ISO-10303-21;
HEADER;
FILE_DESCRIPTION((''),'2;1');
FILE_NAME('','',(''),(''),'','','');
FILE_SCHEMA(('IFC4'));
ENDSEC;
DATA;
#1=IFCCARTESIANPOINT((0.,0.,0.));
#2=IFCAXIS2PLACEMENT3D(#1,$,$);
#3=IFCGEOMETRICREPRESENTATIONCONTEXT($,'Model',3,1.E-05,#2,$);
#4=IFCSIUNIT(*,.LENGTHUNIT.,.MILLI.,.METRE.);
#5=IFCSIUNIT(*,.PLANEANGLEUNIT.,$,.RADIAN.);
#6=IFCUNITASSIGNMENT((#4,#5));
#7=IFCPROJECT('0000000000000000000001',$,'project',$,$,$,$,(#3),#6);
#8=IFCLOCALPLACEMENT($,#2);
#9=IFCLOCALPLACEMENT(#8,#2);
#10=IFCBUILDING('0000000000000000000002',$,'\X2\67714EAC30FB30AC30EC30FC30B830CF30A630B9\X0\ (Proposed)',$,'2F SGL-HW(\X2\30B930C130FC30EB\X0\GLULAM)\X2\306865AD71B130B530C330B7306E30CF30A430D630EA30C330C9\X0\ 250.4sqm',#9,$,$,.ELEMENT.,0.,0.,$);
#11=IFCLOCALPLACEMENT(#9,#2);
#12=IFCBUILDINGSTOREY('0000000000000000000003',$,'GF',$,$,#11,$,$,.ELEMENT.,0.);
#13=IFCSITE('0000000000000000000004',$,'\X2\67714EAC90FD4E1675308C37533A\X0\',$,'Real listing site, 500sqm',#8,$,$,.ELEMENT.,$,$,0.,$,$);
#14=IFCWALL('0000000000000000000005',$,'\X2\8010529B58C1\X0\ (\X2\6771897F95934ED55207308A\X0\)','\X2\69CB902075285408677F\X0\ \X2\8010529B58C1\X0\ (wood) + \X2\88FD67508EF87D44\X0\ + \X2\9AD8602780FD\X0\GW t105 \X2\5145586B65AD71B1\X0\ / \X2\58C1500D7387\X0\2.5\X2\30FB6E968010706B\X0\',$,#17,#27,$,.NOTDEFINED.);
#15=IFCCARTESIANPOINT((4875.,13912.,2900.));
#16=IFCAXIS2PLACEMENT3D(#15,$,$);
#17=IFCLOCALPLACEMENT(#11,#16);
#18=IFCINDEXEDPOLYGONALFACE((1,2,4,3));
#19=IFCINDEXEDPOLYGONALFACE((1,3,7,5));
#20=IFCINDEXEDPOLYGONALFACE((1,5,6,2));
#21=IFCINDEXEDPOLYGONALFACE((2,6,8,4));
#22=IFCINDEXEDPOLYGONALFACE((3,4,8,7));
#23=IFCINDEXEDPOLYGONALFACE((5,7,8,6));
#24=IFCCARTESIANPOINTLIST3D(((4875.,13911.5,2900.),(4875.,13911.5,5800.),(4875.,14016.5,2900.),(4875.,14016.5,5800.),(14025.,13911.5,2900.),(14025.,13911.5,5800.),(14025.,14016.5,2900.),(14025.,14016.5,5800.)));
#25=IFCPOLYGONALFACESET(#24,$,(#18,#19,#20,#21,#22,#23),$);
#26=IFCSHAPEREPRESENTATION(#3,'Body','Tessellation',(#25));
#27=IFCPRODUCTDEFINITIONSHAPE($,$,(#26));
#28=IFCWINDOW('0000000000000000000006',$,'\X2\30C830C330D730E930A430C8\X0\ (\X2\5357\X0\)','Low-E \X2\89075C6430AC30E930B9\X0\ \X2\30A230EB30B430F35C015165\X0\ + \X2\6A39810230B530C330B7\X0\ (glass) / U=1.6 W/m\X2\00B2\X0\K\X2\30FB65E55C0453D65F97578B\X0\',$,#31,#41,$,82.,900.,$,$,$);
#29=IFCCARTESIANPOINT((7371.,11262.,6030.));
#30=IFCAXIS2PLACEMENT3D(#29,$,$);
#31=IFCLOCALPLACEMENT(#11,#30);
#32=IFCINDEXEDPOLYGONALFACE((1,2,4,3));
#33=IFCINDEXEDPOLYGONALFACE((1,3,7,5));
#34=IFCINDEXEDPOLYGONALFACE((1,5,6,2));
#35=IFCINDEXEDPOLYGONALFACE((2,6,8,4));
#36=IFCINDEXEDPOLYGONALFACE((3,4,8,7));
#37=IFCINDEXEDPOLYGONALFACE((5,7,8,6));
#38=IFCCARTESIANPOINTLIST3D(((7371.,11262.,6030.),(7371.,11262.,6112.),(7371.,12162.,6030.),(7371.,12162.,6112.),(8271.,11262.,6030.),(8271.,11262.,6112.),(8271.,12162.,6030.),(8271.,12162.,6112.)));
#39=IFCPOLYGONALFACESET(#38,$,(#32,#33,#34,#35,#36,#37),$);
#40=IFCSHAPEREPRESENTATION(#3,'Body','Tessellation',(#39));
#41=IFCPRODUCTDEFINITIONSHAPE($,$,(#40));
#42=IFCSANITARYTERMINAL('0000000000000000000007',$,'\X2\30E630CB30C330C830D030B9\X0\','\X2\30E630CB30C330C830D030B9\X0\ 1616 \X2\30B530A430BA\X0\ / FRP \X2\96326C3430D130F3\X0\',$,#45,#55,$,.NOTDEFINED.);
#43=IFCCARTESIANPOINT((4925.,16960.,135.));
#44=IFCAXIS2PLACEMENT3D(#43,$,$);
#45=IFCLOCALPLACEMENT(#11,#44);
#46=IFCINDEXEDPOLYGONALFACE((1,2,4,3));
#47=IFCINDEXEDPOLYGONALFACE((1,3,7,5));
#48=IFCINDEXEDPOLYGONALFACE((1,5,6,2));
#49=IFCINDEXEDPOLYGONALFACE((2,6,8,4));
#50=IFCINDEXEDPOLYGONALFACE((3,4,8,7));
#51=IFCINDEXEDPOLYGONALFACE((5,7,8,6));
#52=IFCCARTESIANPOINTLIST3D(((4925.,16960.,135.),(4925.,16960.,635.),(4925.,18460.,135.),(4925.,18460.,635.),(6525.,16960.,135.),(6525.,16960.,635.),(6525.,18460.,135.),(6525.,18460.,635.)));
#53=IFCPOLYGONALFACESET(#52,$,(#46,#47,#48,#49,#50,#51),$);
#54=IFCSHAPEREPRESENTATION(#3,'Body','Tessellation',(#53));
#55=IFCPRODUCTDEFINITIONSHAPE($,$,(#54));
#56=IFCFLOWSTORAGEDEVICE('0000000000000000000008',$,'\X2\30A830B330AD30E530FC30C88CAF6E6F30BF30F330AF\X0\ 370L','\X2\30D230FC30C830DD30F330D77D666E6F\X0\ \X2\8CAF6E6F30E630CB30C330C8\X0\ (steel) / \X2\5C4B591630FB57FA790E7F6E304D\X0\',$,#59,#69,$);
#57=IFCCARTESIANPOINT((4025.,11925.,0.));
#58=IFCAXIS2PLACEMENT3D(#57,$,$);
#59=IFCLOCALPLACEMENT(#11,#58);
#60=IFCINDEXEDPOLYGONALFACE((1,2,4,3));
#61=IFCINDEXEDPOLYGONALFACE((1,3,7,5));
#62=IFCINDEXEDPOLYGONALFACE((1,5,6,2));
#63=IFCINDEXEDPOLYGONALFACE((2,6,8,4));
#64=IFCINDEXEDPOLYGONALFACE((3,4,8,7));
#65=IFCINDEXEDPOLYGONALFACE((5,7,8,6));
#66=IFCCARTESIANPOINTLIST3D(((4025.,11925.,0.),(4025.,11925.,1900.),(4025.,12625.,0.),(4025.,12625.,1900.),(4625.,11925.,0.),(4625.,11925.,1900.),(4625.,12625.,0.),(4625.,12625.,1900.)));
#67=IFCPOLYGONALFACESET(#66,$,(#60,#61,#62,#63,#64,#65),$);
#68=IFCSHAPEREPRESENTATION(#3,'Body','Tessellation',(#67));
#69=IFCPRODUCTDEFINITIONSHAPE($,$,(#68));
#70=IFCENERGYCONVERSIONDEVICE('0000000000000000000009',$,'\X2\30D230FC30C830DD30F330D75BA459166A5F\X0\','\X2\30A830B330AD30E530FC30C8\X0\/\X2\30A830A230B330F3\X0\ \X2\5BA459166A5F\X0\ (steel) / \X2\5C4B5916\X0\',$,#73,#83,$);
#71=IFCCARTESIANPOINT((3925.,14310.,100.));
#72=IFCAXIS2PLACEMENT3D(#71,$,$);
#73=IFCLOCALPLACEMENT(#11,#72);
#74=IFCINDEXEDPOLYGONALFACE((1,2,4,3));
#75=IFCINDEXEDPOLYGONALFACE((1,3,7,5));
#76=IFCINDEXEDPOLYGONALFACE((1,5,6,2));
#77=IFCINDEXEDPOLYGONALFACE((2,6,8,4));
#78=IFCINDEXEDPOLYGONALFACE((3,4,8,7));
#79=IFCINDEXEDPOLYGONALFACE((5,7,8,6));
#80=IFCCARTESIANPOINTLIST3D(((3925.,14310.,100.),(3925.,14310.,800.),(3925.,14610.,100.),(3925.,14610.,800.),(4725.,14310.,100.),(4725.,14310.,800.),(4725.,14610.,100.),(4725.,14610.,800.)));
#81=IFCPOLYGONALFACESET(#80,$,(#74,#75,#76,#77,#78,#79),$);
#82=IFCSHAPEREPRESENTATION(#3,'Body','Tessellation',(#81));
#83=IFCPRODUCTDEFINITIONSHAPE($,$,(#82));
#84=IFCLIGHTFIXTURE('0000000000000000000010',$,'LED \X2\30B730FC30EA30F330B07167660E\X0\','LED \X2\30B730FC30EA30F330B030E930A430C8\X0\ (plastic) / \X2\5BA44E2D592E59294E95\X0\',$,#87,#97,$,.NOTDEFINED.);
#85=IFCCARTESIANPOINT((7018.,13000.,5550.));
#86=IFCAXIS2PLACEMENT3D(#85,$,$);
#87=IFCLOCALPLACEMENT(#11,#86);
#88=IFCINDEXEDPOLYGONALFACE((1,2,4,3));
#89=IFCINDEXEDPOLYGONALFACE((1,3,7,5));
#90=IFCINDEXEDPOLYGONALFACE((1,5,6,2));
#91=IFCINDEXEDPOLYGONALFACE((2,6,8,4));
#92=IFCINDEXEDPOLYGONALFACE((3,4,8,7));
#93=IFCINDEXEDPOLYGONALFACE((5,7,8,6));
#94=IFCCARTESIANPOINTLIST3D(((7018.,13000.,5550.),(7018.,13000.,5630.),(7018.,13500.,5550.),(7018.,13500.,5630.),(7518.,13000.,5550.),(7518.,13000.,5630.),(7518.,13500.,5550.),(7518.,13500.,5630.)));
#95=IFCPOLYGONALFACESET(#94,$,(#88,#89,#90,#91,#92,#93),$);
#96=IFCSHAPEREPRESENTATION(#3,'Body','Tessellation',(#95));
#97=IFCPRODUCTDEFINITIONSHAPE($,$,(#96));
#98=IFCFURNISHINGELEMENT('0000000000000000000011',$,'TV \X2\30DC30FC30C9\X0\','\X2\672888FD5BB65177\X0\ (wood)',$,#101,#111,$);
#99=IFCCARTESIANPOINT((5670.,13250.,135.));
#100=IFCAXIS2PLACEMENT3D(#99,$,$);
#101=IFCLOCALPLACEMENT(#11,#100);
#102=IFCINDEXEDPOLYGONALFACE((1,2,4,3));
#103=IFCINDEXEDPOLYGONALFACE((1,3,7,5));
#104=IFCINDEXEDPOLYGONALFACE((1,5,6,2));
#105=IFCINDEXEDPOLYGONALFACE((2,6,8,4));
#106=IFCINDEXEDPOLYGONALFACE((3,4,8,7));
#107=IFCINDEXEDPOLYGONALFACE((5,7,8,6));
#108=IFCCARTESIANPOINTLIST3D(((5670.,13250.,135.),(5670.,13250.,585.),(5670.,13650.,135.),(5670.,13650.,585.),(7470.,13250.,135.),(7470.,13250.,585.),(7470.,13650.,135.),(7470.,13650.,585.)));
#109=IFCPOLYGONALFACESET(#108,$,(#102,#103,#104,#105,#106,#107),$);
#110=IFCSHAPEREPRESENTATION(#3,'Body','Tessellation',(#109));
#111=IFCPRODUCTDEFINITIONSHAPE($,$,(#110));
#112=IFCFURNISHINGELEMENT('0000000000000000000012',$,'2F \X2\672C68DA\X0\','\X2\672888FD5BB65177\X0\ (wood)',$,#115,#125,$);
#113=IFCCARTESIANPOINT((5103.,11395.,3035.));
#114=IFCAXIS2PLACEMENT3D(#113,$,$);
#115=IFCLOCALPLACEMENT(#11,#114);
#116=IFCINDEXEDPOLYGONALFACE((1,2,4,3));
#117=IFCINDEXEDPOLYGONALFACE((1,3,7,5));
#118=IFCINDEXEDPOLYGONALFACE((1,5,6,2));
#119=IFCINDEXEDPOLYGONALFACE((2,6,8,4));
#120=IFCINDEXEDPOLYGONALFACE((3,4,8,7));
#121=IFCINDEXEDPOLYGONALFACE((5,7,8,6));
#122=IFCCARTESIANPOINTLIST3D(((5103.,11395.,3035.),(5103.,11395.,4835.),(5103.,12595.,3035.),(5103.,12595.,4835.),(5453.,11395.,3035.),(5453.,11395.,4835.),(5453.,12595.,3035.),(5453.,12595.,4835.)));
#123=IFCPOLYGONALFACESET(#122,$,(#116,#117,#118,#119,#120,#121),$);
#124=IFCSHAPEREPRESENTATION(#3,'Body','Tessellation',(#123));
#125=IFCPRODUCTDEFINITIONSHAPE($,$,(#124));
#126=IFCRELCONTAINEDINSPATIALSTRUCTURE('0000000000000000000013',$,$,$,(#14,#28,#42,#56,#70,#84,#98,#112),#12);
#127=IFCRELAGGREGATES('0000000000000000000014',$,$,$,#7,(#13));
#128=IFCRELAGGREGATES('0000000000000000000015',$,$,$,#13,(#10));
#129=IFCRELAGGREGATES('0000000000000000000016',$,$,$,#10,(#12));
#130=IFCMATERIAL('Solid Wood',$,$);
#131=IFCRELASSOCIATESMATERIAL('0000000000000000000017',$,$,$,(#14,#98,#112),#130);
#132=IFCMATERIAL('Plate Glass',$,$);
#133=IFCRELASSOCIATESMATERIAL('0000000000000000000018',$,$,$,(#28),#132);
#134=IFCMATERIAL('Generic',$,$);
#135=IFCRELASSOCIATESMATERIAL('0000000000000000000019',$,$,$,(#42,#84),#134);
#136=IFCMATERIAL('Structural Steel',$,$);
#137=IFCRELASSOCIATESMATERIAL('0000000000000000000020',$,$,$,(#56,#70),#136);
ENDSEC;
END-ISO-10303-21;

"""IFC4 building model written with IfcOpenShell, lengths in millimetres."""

from ifc_helpers import new_model, si_unit, frame, frame_2d, origin, place, context, project, spatial, rectangle, extrude, material, element, save


model = new_model("IFC4")

# Units and contexts
model_context = context("Model", 3, precision=1e-05, world=origin())
ifc_project = project(units=[si_unit("LENGTHUNIT", "METRE", prefix="MILLI"), si_unit("PLANEANGLEUNIT", "RADIAN")], contexts=[model_context])

# Site, building, storey
site_placement = place(None, origin())
site = spatial("IfcSite", under=ifc_project, at=site_placement, Name="東京都世田谷区", ObjectType="Real listing site, 500sqm", CompositionType="ELEMENT", RefElevation=0.0)
building_placement = place(site_placement, origin())
building = spatial("IfcBuilding", under=site, at=building_placement, Name="東京・ガレージハウス (Proposed)", ObjectType="2F SGL-HW(スチールGLULAM)と断熱サッシのハイブリッド 250.4sqm", CompositionType="ELEMENT", ElevationOfRefHeight=0.0, ElevationOfTerrain=0.0)
storey_placement = place(building_placement, origin())
storey = spatial("IfcBuildingStorey", under=building, at=storey_placement, Name="GF", CompositionType="ELEMENT", Elevation=0.0)

# Shared definitions
ifc_material_1 = material(Name="Solid Wood")

# Wall
wall_1_placement = place(storey_placement, frame((4875.0, 13912.0, 2900.0)))
element("IfcWall", 1, at=wall_1_placement, inside=storey, material=ifc_material_1, Name="耐力壁 (東西間仕切り)", Description="構造用合板 耐力壁 (wood) + 製材軸組 + 高性能GW t105 充填断熱 / 壁倍率2.5・準耐火", PredefinedType="NOTDEFINED", context=model_context, shape_type="SweptSolid", body=[
    extrude(rectangle(XDim=9150.0, YDim=105.0, at=frame_2d((4575.0, 52.0))), frame((4875.0, 13912.0, 2900.0)), (0.0, 0.0, 1.0), 2900.0),
])

# Window
ifc_material_2 = material(Name="Plate Glass")
window_placement = place(storey_placement, frame((7371.0, 11262.0, 6030.0)))
element("IfcWindow", 2, at=window_placement, inside=storey, material=ifc_material_2, Name="トップライト (南)", Description="Low-E 複層ガラス アルゴン封入 + 樹脂サッシ (glass) / U=1.6 W/m²K・日射取得型", OverallHeight=82.0, OverallWidth=900.0, context=model_context, shape_type="SweptSolid", body=[
    extrude(rectangle(XDim=900.0, YDim=900.0, at=frame_2d((450.0, 450.0))), frame((7371.0, 11262.0, 6030.0)), (0.0, 0.0, 1.0), 82.0),
])

# Sanitary terminal
ifc_material_3 = material(Name="Generic")
sanitary_terminal_placement = place(storey_placement, frame((4925.0, 16960.0, 135.0)))
element("IfcSanitaryTerminal", 3, at=sanitary_terminal_placement, inside=storey, material=ifc_material_3, Name="ユニットバス", Description="ユニットバス 1616 サイズ / FRP 防水パン", PredefinedType="NOTDEFINED", context=model_context, shape_type="SweptSolid", body=[
    extrude(rectangle(XDim=1600.0, YDim=1500.0, at=frame_2d((800.0, 750.0))), frame((4925.0, 16960.0, 135.0)), (0.0, 0.0, 1.0), 500.0),
])

# Flow storage device
ifc_material_4 = material(Name="Structural Steel")
flow_storage_device_placement = place(storey_placement, frame((4025.0, 11925.0, 0.0)))
element("IfcFlowStorageDevice", 4, at=flow_storage_device_placement, inside=storey, material=ifc_material_4, Name="エコキュート貯湯タンク 370L", Description="ヒートポンプ給湯 貯湯ユニット (steel) / 屋外・基礎置き", context=model_context, shape_type="SweptSolid", body=[
    extrude(rectangle(XDim=600.0, YDim=700.0, at=frame_2d((300.0, 350.0))), frame((4025.0, 11925.0, 0.0)), (0.0, 0.0, 1.0), 1900.0),
])

# Energy conversion device
energy_conversion_device_placement = place(storey_placement, frame((3925.0, 14310.0, 100.0)))
element("IfcEnergyConversionDevice", 5, at=energy_conversion_device_placement, inside=storey, material=ifc_material_4, Name="ヒートポンプ室外機", Description="エコキュート/エアコン 室外機 (steel) / 屋外", context=model_context, shape_type="SweptSolid", body=[
    extrude(rectangle(XDim=800.0, YDim=300.0, at=frame_2d((400.0, 150.0))), frame((3925.0, 14310.0, 100.0)), (0.0, 0.0, 1.0), 700.0),
])

# Light fixture
light_fixture_placement = place(storey_placement, frame((7018.0, 13000.0, 5550.0)))
element("IfcLightFixture", 6, at=light_fixture_placement, inside=storey, material=ifc_material_3, Name="LED シーリング照明", Description="LED シーリングライト (plastic) / 室中央天井", PredefinedType="NOTDEFINED", context=model_context, shape_type="SweptSolid", body=[
    extrude(rectangle(XDim=500.0, YDim=500.0, at=frame_2d((250.0, 250.0))), frame((7018.0, 13000.0, 5550.0)), (0.0, 0.0, 1.0), 80.0),
])

# Furnishing elements
furnishing_1_placement = place(storey_placement, frame((5670.0, 13250.0, 135.0)))
element("IfcFurnishingElement", 7, at=furnishing_1_placement, inside=storey, material=ifc_material_1, Name="TV ボード", Description="木製家具 (wood)", context=model_context, shape_type="SweptSolid", body=[
    extrude(rectangle(XDim=1800.0, YDim=400.0, at=frame_2d((900.0, 200.0))), frame((5670.0, 13250.0, 135.0)), (0.0, 0.0, 1.0), 450.0),
])
furnishing_2_placement = place(storey_placement, frame((5103.0, 11395.0, 3035.0)))
element("IfcFurnishingElement", 8, at=furnishing_2_placement, inside=storey, material=ifc_material_1, Name="2F 本棚", Description="木製家具 (wood)", context=model_context, shape_type="SweptSolid", body=[
    extrude(rectangle(XDim=350.0, YDim=1200.0, at=frame_2d((175.0, 600.0))), frame((5103.0, 11395.0, 3035.0)), (0.0, 0.0, 1.0), 1800.0),
])

save(model, "model.ifc")
